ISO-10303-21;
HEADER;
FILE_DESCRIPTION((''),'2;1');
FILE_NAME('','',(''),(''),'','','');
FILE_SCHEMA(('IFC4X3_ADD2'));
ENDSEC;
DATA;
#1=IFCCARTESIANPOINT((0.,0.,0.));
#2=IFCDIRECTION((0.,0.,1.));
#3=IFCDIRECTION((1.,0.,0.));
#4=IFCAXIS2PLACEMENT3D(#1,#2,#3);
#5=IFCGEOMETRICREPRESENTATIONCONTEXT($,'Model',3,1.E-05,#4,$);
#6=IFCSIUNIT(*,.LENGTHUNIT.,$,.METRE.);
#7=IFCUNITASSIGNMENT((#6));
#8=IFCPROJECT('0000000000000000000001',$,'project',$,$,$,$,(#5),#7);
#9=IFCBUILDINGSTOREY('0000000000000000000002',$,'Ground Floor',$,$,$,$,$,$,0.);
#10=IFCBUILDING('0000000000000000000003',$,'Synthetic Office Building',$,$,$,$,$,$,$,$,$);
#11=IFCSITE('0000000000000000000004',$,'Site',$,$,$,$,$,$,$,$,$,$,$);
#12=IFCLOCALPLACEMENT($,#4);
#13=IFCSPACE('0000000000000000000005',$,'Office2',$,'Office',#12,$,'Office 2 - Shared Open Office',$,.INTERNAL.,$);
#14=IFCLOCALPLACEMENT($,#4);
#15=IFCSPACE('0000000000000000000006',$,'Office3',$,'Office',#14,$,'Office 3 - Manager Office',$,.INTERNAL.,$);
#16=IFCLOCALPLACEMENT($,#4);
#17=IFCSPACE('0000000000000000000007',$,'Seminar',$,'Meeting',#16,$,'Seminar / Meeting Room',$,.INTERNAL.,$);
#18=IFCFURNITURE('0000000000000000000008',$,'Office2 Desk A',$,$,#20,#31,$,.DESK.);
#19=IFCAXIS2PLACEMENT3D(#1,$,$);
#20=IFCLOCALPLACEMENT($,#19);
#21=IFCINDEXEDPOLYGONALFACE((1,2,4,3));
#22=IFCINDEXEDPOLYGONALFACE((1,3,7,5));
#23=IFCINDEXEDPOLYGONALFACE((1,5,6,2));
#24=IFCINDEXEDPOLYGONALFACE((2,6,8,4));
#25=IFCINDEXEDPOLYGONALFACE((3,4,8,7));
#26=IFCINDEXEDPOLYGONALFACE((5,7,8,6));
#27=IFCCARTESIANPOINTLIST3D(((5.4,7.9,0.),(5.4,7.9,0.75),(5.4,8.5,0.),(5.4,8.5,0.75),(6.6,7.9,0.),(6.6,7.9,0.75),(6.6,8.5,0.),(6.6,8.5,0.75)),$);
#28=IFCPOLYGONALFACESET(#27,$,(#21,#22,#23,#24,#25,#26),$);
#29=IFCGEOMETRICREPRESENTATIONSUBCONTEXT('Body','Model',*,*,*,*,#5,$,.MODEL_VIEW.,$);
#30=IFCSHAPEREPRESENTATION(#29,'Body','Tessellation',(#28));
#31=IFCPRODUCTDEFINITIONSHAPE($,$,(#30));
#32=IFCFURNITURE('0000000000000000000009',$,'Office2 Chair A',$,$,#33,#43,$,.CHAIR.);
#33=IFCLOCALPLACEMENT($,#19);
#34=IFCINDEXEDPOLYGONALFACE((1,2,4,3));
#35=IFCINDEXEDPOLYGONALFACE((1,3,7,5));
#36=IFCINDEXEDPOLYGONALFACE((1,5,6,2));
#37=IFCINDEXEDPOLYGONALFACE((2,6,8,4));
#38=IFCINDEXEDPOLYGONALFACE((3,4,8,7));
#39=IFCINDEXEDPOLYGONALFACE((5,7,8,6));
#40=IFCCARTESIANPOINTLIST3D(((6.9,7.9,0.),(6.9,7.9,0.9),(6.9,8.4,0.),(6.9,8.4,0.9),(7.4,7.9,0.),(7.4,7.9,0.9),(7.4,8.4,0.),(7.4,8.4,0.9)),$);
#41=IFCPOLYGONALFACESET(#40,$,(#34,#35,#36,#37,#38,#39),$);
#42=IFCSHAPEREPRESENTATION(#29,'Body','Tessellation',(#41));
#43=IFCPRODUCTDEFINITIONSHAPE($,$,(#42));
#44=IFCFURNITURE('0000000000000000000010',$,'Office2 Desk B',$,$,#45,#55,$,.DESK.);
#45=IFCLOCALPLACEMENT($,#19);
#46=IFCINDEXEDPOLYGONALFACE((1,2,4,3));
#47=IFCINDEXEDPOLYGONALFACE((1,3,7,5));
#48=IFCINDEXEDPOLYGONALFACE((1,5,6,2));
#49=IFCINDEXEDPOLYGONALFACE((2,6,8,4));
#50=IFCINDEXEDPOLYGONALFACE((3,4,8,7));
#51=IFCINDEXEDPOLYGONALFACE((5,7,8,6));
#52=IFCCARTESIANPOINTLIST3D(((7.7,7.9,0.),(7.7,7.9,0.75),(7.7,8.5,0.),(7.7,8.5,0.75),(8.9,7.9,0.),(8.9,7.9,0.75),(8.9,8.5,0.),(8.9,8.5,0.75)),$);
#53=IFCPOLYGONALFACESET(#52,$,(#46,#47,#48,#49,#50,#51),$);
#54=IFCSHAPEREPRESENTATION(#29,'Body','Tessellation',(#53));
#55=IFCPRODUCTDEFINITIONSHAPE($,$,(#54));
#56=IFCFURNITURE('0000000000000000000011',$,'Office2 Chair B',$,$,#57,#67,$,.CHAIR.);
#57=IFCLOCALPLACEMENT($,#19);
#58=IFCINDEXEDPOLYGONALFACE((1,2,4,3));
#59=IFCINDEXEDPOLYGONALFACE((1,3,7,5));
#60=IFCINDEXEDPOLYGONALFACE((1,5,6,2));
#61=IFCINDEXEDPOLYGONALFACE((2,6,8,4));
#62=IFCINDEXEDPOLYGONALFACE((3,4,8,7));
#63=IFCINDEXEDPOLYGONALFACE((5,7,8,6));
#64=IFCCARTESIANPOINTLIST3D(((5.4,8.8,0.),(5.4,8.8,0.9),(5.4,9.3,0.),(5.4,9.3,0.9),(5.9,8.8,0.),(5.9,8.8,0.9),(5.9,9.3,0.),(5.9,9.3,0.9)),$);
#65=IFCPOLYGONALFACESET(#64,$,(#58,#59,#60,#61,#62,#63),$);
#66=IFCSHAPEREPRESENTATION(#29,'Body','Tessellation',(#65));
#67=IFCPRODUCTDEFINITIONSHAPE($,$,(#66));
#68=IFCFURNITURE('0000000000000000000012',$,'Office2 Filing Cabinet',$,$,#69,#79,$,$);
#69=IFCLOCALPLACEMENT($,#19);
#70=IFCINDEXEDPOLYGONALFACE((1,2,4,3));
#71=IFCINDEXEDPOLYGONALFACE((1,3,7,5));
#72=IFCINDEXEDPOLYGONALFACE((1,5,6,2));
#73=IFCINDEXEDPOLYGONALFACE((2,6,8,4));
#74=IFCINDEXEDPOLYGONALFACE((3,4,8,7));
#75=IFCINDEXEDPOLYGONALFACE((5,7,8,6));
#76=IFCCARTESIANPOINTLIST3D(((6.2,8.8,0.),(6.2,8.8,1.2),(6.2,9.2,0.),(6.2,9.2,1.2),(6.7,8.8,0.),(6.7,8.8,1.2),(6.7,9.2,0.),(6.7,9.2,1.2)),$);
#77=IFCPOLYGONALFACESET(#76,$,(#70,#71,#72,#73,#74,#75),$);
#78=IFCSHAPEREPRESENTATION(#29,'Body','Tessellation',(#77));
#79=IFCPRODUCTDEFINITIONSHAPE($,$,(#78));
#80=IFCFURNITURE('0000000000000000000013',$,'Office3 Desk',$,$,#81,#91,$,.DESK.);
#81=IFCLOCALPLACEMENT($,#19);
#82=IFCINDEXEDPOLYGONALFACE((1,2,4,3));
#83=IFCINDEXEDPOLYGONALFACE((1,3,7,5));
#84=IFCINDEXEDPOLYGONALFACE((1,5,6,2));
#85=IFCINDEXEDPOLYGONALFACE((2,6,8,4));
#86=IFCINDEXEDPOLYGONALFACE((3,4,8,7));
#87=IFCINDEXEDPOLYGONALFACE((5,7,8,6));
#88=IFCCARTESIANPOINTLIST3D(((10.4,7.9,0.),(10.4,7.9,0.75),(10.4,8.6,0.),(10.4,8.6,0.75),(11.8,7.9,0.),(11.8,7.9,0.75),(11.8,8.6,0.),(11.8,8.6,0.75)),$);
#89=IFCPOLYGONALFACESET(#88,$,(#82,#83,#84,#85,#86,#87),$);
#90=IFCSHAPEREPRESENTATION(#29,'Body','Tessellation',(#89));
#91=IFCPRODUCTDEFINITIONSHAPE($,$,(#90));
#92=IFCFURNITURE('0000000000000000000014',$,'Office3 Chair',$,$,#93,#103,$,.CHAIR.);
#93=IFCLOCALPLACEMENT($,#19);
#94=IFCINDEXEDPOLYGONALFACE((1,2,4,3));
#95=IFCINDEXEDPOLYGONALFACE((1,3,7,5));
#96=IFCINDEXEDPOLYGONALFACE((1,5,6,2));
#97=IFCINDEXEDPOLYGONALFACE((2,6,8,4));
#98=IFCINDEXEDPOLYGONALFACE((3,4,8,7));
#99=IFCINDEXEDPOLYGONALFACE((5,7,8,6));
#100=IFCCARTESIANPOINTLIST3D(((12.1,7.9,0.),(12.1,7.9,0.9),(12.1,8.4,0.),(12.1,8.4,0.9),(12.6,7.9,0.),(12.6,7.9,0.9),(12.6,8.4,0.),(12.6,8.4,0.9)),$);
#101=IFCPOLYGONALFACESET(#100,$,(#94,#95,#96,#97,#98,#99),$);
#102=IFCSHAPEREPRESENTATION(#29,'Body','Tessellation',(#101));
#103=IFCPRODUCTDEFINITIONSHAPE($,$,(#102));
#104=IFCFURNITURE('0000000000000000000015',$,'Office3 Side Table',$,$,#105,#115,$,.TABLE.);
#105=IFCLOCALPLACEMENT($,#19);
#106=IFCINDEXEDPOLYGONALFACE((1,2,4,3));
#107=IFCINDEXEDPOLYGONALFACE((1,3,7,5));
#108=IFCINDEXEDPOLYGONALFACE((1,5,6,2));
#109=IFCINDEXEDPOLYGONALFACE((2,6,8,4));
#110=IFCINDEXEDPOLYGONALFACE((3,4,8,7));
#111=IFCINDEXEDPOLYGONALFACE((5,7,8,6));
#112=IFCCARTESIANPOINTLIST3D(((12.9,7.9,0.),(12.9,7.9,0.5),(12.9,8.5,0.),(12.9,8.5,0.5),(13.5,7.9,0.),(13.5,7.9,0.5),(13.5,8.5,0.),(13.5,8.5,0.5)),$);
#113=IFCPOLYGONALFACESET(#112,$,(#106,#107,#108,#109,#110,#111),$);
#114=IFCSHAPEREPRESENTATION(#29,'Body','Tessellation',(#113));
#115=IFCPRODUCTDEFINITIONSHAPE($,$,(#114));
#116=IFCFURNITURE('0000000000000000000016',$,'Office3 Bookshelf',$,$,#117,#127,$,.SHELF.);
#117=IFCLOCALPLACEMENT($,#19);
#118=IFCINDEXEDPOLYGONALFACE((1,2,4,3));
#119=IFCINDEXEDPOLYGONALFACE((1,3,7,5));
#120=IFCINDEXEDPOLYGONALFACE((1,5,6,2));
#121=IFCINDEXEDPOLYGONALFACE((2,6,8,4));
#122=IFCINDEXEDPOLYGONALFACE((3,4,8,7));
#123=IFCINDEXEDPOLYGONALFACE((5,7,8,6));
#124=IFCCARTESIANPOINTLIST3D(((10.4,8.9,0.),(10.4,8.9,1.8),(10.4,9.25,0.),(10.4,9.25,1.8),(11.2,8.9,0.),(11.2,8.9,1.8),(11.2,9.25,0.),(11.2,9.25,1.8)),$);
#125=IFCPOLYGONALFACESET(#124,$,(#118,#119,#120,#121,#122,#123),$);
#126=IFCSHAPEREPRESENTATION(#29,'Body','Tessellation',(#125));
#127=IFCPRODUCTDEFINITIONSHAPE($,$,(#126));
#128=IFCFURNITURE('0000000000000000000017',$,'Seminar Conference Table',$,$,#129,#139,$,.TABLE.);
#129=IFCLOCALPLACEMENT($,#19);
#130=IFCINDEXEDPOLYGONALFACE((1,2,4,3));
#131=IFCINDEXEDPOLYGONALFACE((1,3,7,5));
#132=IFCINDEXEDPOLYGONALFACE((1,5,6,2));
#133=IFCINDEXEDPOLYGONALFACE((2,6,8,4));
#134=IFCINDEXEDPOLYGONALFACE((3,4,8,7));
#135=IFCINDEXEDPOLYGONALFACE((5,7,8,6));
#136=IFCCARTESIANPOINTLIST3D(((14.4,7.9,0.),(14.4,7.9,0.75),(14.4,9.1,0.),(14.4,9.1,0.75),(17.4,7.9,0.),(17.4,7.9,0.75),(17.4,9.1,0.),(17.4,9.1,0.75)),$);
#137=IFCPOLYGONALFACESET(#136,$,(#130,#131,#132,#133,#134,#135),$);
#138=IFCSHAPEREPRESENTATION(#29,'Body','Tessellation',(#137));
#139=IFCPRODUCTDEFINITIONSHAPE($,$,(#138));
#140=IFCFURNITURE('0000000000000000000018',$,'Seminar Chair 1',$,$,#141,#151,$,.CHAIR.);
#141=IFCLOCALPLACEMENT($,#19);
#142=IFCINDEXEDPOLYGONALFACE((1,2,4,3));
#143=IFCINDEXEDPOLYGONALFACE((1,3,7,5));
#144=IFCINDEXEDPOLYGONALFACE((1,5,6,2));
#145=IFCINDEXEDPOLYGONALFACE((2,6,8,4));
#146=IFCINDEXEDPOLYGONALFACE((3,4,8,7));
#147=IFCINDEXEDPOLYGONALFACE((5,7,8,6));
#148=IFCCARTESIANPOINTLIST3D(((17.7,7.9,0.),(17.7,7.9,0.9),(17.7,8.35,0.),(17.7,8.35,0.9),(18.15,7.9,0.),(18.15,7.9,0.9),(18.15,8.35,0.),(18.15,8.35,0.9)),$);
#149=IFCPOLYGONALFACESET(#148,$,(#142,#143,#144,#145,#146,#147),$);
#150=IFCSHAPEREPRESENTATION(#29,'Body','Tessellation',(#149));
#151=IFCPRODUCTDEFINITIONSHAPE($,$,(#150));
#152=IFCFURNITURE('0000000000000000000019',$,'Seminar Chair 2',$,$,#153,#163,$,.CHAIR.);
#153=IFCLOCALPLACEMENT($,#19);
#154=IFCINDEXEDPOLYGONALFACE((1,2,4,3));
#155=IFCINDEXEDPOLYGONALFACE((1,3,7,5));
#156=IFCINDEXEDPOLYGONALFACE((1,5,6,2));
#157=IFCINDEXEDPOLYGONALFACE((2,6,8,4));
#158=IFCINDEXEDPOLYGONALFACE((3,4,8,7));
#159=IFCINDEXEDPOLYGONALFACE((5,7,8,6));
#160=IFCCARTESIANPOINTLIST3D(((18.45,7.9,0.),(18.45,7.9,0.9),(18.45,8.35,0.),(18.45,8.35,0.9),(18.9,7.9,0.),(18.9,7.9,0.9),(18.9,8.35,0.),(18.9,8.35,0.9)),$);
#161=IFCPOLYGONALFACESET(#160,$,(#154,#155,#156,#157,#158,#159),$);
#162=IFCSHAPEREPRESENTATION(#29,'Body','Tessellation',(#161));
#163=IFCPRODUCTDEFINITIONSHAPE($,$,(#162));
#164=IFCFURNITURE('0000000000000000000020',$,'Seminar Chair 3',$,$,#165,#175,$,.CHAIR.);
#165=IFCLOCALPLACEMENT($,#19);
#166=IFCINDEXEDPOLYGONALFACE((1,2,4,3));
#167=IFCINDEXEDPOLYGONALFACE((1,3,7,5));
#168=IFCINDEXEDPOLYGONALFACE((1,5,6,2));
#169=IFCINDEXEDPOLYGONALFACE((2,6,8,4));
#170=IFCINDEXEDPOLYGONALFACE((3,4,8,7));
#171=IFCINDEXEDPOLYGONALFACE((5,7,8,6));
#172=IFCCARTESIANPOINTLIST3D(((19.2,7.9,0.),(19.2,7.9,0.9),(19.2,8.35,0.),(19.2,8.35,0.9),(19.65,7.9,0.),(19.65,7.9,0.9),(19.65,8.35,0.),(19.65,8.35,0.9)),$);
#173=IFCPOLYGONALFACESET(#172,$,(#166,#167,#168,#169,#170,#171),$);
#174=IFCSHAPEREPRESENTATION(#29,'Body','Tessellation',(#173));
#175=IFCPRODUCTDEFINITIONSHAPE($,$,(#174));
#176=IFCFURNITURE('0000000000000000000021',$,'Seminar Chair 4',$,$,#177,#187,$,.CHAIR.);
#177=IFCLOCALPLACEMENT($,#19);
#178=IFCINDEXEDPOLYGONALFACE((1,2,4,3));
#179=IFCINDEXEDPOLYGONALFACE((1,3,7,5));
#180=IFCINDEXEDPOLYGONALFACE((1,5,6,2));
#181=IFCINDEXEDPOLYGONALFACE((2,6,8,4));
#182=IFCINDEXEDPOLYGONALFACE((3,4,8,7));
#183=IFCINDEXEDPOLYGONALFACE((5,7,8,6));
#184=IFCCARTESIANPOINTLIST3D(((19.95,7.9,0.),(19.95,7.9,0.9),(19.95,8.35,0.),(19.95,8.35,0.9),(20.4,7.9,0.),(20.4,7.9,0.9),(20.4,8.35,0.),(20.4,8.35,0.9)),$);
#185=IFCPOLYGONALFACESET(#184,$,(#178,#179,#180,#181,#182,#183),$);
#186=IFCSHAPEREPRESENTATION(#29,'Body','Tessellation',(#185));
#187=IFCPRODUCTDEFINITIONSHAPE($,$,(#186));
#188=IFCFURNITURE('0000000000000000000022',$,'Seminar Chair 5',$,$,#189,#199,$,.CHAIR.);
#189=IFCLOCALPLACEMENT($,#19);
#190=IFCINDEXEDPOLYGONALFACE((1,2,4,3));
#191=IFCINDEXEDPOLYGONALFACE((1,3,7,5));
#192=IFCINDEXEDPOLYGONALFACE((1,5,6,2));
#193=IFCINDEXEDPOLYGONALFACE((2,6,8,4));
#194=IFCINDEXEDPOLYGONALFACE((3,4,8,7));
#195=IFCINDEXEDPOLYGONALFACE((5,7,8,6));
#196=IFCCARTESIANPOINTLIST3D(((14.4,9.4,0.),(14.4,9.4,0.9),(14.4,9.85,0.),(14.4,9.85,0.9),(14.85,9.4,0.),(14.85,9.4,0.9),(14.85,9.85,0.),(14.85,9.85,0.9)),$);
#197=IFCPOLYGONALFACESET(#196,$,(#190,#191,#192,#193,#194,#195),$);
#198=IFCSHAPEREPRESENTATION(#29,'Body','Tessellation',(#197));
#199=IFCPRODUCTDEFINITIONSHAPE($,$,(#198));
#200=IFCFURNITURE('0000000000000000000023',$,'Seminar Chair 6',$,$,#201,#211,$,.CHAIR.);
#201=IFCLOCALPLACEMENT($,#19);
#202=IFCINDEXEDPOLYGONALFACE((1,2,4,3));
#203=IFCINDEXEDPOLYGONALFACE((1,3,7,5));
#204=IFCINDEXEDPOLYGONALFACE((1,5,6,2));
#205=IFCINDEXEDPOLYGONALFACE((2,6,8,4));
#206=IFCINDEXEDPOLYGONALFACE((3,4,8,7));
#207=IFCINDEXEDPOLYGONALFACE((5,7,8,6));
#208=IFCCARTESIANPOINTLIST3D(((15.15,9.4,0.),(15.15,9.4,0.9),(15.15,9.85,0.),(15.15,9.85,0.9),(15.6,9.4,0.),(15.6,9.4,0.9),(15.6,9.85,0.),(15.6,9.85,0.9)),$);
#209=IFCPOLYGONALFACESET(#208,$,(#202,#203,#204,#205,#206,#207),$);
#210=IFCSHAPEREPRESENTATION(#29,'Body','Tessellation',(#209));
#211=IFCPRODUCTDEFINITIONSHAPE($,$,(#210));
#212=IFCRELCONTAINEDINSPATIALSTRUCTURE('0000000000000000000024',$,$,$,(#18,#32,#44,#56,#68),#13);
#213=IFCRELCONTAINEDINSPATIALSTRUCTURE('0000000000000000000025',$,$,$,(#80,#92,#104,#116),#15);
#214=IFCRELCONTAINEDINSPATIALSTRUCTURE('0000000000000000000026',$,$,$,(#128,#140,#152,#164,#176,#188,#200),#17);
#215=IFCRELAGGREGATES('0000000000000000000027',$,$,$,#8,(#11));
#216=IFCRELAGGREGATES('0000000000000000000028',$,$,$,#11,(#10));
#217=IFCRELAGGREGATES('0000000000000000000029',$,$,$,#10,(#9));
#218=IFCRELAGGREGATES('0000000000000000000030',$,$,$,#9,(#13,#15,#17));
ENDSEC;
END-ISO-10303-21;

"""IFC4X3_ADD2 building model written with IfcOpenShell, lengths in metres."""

from ifc_helpers import new_model, si_unit, origin_with_axes, place, context, subcontext, project, spatial, polyline, outline, extrude, element, save


model = new_model("IFC4X3_ADD2")

# Units and contexts
model_context = context("Model", 3, precision=1e-05, world=origin_with_axes())
body_context = subcontext(model_context, "Body", "Model", "MODEL_VIEW")
ifc_project = project(units=[si_unit("LENGTHUNIT", "METRE")], contexts=[model_context])

# Site, building, storey, space
site = spatial("IfcSite", under=ifc_project, Name="Site")
building = spatial("IfcBuilding", under=site, Name="Synthetic Office Building")
storey = spatial("IfcBuildingStorey", under=building, Name="Ground Floor", Elevation=0.0)
space_1_placement = place(None, origin_with_axes())
space_1 = spatial("IfcSpace", under=storey, at=space_1_placement, Name="Office2", ObjectType="Office", LongName="Office 2 - Shared Open Office", PredefinedType="INTERNAL")

# Furniture
furniture_1_placement = place(space_1_placement, origin_with_axes())
element("IfcFurniture", 1, at=furniture_1_placement, inside=space_1, Name="Office2 Desk A", PredefinedType="DESK", context=body_context, shape_type="SweptSolid", body=[
    extrude(outline(polyline([(5.4, 7.9), (6.6, 7.9), (6.6, 8.5), (5.4, 8.5), (5.4, 7.9)])), origin_with_axes(), (0.0, 0.0, 1.0), 0.75),
])
furniture_2_placement = place(space_1_placement, origin_with_axes())
element("IfcFurniture", 2, at=furniture_2_placement, inside=space_1, Name="Office2 Chair A", PredefinedType="CHAIR", context=body_context, shape_type="SweptSolid", body=[
    extrude(outline(polyline([(6.9, 7.9), (7.4, 7.9), (7.4, 8.4), (6.9, 8.4), (6.9, 7.9)])), origin_with_axes(), (0.0, 0.0, 1.0), 0.9),
])
furniture_3_placement = place(space_1_placement, origin_with_axes())
element("IfcFurniture", 3, at=furniture_3_placement, inside=space_1, Name="Office2 Desk B", PredefinedType="DESK", context=body_context, shape_type="SweptSolid", body=[
    extrude(outline(polyline([(7.7, 7.9), (8.9, 7.9), (8.9, 8.5), (7.7, 8.5), (7.7, 7.9)])), origin_with_axes(), (0.0, 0.0, 1.0), 0.75),
])
furniture_4_placement = place(space_1_placement, origin_with_axes())
element("IfcFurniture", 4, at=furniture_4_placement, inside=space_1, Name="Office2 Chair B", PredefinedType="CHAIR", context=body_context, shape_type="SweptSolid", body=[
    extrude(outline(polyline([(5.4, 8.8), (5.9, 8.8), (5.9, 9.3), (5.4, 9.3), (5.4, 8.8)])), origin_with_axes(), (0.0, 0.0, 1.0), 0.9),
])
furniture_5_placement = place(space_1_placement, origin_with_axes())
element("IfcFurniture", 5, at=furniture_5_placement, inside=space_1, Name="Office2 Filing Cabinet", context=body_context, shape_type="SweptSolid", body=[
    extrude(outline(polyline([(6.2, 8.8), (6.7, 8.8), (6.7, 9.2), (6.2, 9.2), (6.2, 8.8)])), origin_with_axes(), (0.0, 0.0, 1.0), 1.2),
])

# Shared definitions
space_2_placement = place(None, origin_with_axes())
space_2 = spatial("IfcSpace", under=storey, at=space_2_placement, Name="Office3", ObjectType="Office", LongName="Office 3 - Manager Office", PredefinedType="INTERNAL")

# Furniture
furniture_6_placement = place(space_2_placement, origin_with_axes())
element("IfcFurniture", 6, at=furniture_6_placement, inside=space_2, Name="Office3 Desk", PredefinedType="DESK", context=body_context, shape_type="SweptSolid", body=[
    extrude(outline(polyline([(10.4, 7.9), (11.8, 7.9), (11.8, 8.6), (10.4, 8.6), (10.4, 7.9)])), origin_with_axes(), (0.0, 0.0, 1.0), 0.75),
])
furniture_7_placement = place(space_2_placement, origin_with_axes())
element("IfcFurniture", 7, at=furniture_7_placement, inside=space_2, Name="Office3 Chair", PredefinedType="CHAIR", context=body_context, shape_type="SweptSolid", body=[
    extrude(outline(polyline([(12.1, 7.9), (12.6, 7.9), (12.6, 8.4), (12.1, 8.4), (12.1, 7.9)])), origin_with_axes(), (0.0, 0.0, 1.0), 0.9),
])
furniture_8_placement = place(space_2_placement, origin_with_axes())
element("IfcFurniture", 8, at=furniture_8_placement, inside=space_2, Name="Office3 Side Table", PredefinedType="TABLE", context=body_context, shape_type="SweptSolid", body=[
    extrude(outline(polyline([(12.9, 7.9), (13.5, 7.9), (13.5, 8.5), (12.9, 8.5), (12.9, 7.9)])), origin_with_axes(), (0.0, 0.0, 1.0), 0.5),
])
furniture_9_placement = place(space_2_placement, origin_with_axes())
element("IfcFurniture", 9, at=furniture_9_placement, inside=space_2, Name="Office3 Bookshelf", PredefinedType="SHELF", context=body_context, shape_type="SweptSolid", body=[
    extrude(outline(polyline([(10.4, 8.9), (11.2, 8.9), (11.2, 9.25), (10.4, 9.25), (10.4, 8.9)])), origin_with_axes(), (0.0, 0.0, 1.0), 1.8),
])

# Shared definitions
space_3_placement = place(None, origin_with_axes())
space_3 = spatial("IfcSpace", under=storey, at=space_3_placement, Name="Seminar", ObjectType="Meeting", LongName="Seminar / Meeting Room", PredefinedType="INTERNAL")

# Furniture
furniture_10_placement = place(space_3_placement, origin_with_axes())
element("IfcFurniture", 10, at=furniture_10_placement, inside=space_3, Name="Seminar Conference Table", PredefinedType="TABLE", context=body_context, shape_type="SweptSolid", body=[
    extrude(outline(polyline([(14.4, 7.9), (17.4, 7.9), (17.4, 9.1), (14.4, 9.1), (14.4, 7.9)])), origin_with_axes(), (0.0, 0.0, 1.0), 0.75),
])
furniture_11_placement = place(space_3_placement, origin_with_axes())
element("IfcFurniture", 11, at=furniture_11_placement, inside=space_3, Name="Seminar Chair 1", PredefinedType="CHAIR", context=body_context, shape_type="SweptSolid", body=[
    extrude(outline(polyline([(17.7, 7.9), (18.15, 7.9), (18.15, 8.35), (17.7, 8.35), (17.7, 7.9)])), origin_with_axes(), (0.0, 0.0, 1.0), 0.9),
])
furniture_12_placement = place(space_3_placement, origin_with_axes())
element("IfcFurniture", 12, at=furniture_12_placement, inside=space_3, Name="Seminar Chair 2", PredefinedType="CHAIR", context=body_context, shape_type="SweptSolid", body=[
    extrude(outline(polyline([(18.45, 7.9), (18.9, 7.9), (18.9, 8.35), (18.45, 8.35), (18.45, 7.9)])), origin_with_axes(), (0.0, 0.0, 1.0), 0.9),
])
furniture_13_placement = place(space_3_placement, origin_with_axes())
element("IfcFurniture", 13, at=furniture_13_placement, inside=space_3, Name="Seminar Chair 3", PredefinedType="CHAIR", context=body_context, shape_type="SweptSolid", body=[
    extrude(outline(polyline([(19.2, 7.9), (19.65, 7.9), (19.65, 8.35), (19.2, 8.35), (19.2, 7.9)])), origin_with_axes(), (0.0, 0.0, 1.0), 0.9),
])
furniture_14_placement = place(space_3_placement, origin_with_axes())
element("IfcFurniture", 14, at=furniture_14_placement, inside=space_3, Name="Seminar Chair 4", PredefinedType="CHAIR", context=body_context, shape_type="SweptSolid", body=[
    extrude(outline(polyline([(19.95, 7.9), (20.4, 7.9), (20.4, 8.35), (19.95, 8.35), (19.95, 7.9)])), origin_with_axes(), (0.0, 0.0, 1.0), 0.9),
])
furniture_15_placement = place(space_3_placement, origin_with_axes())
element("IfcFurniture", 15, at=furniture_15_placement, inside=space_3, Name="Seminar Chair 5", PredefinedType="CHAIR", context=body_context, shape_type="SweptSolid", body=[
    extrude(outline(polyline([(14.4, 9.4), (14.85, 9.4), (14.85, 9.85), (14.4, 9.85), (14.4, 9.4)])), origin_with_axes(), (0.0, 0.0, 1.0), 0.9),
])
furniture_16_placement = place(space_3_placement, origin_with_axes())
element("IfcFurniture", 16, at=furniture_16_placement, inside=space_3, Name="Seminar Chair 6", PredefinedType="CHAIR", context=body_context, shape_type="SweptSolid", body=[
    extrude(outline(polyline([(15.15, 9.4), (15.6, 9.4), (15.6, 9.85), (15.15, 9.85), (15.15, 9.4)])), origin_with_axes(), (0.0, 0.0, 1.0), 0.9),
])

save(model, "model.ifc")
